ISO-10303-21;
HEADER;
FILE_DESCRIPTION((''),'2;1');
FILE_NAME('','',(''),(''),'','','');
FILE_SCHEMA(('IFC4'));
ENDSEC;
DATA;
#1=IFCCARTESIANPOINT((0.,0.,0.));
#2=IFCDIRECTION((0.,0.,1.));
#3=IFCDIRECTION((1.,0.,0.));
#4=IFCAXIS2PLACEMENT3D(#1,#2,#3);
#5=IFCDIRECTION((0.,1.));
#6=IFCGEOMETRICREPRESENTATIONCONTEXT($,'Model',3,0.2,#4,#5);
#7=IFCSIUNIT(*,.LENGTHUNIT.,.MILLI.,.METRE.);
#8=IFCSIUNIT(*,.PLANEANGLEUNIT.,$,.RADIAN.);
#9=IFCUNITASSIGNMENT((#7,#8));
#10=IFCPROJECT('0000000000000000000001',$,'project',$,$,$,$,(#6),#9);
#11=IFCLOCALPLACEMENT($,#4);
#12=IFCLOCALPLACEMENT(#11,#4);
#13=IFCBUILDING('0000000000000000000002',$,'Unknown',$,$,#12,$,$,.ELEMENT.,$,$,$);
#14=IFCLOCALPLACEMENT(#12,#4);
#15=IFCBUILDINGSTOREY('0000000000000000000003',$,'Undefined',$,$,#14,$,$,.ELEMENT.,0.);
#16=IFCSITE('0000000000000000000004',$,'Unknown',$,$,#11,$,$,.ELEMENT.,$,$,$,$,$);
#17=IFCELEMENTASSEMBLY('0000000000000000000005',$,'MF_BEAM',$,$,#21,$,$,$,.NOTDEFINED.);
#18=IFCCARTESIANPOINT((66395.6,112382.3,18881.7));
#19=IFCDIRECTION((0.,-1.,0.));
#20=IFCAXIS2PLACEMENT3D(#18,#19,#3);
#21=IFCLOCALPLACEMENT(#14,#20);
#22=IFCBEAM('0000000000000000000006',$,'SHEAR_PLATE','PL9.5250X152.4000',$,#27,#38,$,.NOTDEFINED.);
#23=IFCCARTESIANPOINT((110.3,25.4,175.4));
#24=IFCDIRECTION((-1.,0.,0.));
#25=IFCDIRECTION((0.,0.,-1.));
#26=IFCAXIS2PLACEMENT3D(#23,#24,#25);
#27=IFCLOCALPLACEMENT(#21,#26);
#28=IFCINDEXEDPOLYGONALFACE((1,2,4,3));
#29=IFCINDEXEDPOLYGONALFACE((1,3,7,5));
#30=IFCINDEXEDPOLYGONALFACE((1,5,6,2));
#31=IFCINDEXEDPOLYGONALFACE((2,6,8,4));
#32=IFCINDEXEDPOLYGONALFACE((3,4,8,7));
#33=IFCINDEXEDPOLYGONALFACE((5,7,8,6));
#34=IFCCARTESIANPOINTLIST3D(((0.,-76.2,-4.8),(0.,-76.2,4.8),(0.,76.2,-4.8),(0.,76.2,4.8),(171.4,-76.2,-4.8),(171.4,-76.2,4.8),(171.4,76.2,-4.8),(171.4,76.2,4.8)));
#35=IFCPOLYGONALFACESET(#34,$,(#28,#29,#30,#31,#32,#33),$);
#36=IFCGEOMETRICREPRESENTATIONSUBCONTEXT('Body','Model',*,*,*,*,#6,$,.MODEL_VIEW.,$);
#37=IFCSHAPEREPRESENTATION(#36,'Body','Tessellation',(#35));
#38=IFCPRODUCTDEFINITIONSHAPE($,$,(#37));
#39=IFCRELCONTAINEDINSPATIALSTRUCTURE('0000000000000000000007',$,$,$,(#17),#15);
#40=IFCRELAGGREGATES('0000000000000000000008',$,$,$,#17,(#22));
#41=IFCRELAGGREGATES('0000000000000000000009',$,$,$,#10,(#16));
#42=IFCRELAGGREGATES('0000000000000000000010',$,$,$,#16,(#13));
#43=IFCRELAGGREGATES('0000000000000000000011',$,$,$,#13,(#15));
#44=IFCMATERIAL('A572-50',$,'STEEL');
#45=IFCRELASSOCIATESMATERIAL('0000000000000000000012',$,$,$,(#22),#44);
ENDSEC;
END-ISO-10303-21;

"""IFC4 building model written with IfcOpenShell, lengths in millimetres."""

from ifc_helpers import new_model, si_unit, direction, frame, origin_with_axes, place, context, subcontext, project, spatial, line, indexed_curve, outline, extrude, material, element, aggregate, save


model = new_model("IFC4")

# Units and contexts
model_context = context("Model", 3, precision=0.2, world=origin_with_axes(), true_north=direction((0.0, 1.0)))
body_context = subcontext(model_context, "Body", "Model", "MODEL_VIEW")
ifc_project = project(units=[si_unit("LENGTHUNIT", "METRE", prefix="MILLI"), si_unit("PLANEANGLEUNIT", "RADIAN")], contexts=[model_context])

# Site, building, storey
site_placement = place(None, origin_with_axes())
site = spatial("IfcSite", under=ifc_project, at=site_placement, Name="Unknown", CompositionType="ELEMENT")
building_placement = place(site_placement, origin_with_axes())
building = spatial("IfcBuilding", under=site, at=building_placement, Name="Unknown", CompositionType="ELEMENT")
storey_placement = place(building_placement, origin_with_axes())
storey = spatial("IfcBuildingStorey", under=building, at=storey_placement, Name="Undefined", CompositionType="ELEMENT", Elevation=0.0)

# Element assembly, beam
assembly_1_placement = place(storey_placement, frame((66395.6, 112382.3, 18881.7), z_axis=(0.0, -1.0, 0.0), x_axis=(1.0, 0.0, 0.0)))
assembly_1 = element("IfcElementAssembly", 1, at=assembly_1_placement, inside=storey, Name="MF_BEAM", PredefinedType="NOTDEFINED")
ifc_material_1 = material(Name="A572-50", Category="STEEL")
beam_1_placement = place(assembly_1_placement, frame((110.3, 25.4, 175.4), z_axis=(-1.0, 0.0, 0.0), x_axis=(0.0, 0.0, -1.0)))
beam_1 = element("IfcBeam", 2, at=beam_1_placement, material=ifc_material_1, Name="SHEAR_PLATE", Description="PL9.5250X152.4000", PredefinedType="NOTDEFINED", context=body_context, shape_type="SolidModel", body=[
    extrude(outline(indexed_curve([(-4.8, -76.2), (4.8, -76.2), (4.8, 76.2), (-4.8, 76.2)], segments=[line(1, 2, 3, 4, 1)])), frame((0.0, 0.0, 0.0), z_axis=(-1.0, 0.0, 0.0), x_axis=(0.0, 0.0, 1.0)), (0.0, 0.0, -1.0), 171.4),
])
aggregate(assembly_1, [beam_1])

save(model, "model.ifc")
